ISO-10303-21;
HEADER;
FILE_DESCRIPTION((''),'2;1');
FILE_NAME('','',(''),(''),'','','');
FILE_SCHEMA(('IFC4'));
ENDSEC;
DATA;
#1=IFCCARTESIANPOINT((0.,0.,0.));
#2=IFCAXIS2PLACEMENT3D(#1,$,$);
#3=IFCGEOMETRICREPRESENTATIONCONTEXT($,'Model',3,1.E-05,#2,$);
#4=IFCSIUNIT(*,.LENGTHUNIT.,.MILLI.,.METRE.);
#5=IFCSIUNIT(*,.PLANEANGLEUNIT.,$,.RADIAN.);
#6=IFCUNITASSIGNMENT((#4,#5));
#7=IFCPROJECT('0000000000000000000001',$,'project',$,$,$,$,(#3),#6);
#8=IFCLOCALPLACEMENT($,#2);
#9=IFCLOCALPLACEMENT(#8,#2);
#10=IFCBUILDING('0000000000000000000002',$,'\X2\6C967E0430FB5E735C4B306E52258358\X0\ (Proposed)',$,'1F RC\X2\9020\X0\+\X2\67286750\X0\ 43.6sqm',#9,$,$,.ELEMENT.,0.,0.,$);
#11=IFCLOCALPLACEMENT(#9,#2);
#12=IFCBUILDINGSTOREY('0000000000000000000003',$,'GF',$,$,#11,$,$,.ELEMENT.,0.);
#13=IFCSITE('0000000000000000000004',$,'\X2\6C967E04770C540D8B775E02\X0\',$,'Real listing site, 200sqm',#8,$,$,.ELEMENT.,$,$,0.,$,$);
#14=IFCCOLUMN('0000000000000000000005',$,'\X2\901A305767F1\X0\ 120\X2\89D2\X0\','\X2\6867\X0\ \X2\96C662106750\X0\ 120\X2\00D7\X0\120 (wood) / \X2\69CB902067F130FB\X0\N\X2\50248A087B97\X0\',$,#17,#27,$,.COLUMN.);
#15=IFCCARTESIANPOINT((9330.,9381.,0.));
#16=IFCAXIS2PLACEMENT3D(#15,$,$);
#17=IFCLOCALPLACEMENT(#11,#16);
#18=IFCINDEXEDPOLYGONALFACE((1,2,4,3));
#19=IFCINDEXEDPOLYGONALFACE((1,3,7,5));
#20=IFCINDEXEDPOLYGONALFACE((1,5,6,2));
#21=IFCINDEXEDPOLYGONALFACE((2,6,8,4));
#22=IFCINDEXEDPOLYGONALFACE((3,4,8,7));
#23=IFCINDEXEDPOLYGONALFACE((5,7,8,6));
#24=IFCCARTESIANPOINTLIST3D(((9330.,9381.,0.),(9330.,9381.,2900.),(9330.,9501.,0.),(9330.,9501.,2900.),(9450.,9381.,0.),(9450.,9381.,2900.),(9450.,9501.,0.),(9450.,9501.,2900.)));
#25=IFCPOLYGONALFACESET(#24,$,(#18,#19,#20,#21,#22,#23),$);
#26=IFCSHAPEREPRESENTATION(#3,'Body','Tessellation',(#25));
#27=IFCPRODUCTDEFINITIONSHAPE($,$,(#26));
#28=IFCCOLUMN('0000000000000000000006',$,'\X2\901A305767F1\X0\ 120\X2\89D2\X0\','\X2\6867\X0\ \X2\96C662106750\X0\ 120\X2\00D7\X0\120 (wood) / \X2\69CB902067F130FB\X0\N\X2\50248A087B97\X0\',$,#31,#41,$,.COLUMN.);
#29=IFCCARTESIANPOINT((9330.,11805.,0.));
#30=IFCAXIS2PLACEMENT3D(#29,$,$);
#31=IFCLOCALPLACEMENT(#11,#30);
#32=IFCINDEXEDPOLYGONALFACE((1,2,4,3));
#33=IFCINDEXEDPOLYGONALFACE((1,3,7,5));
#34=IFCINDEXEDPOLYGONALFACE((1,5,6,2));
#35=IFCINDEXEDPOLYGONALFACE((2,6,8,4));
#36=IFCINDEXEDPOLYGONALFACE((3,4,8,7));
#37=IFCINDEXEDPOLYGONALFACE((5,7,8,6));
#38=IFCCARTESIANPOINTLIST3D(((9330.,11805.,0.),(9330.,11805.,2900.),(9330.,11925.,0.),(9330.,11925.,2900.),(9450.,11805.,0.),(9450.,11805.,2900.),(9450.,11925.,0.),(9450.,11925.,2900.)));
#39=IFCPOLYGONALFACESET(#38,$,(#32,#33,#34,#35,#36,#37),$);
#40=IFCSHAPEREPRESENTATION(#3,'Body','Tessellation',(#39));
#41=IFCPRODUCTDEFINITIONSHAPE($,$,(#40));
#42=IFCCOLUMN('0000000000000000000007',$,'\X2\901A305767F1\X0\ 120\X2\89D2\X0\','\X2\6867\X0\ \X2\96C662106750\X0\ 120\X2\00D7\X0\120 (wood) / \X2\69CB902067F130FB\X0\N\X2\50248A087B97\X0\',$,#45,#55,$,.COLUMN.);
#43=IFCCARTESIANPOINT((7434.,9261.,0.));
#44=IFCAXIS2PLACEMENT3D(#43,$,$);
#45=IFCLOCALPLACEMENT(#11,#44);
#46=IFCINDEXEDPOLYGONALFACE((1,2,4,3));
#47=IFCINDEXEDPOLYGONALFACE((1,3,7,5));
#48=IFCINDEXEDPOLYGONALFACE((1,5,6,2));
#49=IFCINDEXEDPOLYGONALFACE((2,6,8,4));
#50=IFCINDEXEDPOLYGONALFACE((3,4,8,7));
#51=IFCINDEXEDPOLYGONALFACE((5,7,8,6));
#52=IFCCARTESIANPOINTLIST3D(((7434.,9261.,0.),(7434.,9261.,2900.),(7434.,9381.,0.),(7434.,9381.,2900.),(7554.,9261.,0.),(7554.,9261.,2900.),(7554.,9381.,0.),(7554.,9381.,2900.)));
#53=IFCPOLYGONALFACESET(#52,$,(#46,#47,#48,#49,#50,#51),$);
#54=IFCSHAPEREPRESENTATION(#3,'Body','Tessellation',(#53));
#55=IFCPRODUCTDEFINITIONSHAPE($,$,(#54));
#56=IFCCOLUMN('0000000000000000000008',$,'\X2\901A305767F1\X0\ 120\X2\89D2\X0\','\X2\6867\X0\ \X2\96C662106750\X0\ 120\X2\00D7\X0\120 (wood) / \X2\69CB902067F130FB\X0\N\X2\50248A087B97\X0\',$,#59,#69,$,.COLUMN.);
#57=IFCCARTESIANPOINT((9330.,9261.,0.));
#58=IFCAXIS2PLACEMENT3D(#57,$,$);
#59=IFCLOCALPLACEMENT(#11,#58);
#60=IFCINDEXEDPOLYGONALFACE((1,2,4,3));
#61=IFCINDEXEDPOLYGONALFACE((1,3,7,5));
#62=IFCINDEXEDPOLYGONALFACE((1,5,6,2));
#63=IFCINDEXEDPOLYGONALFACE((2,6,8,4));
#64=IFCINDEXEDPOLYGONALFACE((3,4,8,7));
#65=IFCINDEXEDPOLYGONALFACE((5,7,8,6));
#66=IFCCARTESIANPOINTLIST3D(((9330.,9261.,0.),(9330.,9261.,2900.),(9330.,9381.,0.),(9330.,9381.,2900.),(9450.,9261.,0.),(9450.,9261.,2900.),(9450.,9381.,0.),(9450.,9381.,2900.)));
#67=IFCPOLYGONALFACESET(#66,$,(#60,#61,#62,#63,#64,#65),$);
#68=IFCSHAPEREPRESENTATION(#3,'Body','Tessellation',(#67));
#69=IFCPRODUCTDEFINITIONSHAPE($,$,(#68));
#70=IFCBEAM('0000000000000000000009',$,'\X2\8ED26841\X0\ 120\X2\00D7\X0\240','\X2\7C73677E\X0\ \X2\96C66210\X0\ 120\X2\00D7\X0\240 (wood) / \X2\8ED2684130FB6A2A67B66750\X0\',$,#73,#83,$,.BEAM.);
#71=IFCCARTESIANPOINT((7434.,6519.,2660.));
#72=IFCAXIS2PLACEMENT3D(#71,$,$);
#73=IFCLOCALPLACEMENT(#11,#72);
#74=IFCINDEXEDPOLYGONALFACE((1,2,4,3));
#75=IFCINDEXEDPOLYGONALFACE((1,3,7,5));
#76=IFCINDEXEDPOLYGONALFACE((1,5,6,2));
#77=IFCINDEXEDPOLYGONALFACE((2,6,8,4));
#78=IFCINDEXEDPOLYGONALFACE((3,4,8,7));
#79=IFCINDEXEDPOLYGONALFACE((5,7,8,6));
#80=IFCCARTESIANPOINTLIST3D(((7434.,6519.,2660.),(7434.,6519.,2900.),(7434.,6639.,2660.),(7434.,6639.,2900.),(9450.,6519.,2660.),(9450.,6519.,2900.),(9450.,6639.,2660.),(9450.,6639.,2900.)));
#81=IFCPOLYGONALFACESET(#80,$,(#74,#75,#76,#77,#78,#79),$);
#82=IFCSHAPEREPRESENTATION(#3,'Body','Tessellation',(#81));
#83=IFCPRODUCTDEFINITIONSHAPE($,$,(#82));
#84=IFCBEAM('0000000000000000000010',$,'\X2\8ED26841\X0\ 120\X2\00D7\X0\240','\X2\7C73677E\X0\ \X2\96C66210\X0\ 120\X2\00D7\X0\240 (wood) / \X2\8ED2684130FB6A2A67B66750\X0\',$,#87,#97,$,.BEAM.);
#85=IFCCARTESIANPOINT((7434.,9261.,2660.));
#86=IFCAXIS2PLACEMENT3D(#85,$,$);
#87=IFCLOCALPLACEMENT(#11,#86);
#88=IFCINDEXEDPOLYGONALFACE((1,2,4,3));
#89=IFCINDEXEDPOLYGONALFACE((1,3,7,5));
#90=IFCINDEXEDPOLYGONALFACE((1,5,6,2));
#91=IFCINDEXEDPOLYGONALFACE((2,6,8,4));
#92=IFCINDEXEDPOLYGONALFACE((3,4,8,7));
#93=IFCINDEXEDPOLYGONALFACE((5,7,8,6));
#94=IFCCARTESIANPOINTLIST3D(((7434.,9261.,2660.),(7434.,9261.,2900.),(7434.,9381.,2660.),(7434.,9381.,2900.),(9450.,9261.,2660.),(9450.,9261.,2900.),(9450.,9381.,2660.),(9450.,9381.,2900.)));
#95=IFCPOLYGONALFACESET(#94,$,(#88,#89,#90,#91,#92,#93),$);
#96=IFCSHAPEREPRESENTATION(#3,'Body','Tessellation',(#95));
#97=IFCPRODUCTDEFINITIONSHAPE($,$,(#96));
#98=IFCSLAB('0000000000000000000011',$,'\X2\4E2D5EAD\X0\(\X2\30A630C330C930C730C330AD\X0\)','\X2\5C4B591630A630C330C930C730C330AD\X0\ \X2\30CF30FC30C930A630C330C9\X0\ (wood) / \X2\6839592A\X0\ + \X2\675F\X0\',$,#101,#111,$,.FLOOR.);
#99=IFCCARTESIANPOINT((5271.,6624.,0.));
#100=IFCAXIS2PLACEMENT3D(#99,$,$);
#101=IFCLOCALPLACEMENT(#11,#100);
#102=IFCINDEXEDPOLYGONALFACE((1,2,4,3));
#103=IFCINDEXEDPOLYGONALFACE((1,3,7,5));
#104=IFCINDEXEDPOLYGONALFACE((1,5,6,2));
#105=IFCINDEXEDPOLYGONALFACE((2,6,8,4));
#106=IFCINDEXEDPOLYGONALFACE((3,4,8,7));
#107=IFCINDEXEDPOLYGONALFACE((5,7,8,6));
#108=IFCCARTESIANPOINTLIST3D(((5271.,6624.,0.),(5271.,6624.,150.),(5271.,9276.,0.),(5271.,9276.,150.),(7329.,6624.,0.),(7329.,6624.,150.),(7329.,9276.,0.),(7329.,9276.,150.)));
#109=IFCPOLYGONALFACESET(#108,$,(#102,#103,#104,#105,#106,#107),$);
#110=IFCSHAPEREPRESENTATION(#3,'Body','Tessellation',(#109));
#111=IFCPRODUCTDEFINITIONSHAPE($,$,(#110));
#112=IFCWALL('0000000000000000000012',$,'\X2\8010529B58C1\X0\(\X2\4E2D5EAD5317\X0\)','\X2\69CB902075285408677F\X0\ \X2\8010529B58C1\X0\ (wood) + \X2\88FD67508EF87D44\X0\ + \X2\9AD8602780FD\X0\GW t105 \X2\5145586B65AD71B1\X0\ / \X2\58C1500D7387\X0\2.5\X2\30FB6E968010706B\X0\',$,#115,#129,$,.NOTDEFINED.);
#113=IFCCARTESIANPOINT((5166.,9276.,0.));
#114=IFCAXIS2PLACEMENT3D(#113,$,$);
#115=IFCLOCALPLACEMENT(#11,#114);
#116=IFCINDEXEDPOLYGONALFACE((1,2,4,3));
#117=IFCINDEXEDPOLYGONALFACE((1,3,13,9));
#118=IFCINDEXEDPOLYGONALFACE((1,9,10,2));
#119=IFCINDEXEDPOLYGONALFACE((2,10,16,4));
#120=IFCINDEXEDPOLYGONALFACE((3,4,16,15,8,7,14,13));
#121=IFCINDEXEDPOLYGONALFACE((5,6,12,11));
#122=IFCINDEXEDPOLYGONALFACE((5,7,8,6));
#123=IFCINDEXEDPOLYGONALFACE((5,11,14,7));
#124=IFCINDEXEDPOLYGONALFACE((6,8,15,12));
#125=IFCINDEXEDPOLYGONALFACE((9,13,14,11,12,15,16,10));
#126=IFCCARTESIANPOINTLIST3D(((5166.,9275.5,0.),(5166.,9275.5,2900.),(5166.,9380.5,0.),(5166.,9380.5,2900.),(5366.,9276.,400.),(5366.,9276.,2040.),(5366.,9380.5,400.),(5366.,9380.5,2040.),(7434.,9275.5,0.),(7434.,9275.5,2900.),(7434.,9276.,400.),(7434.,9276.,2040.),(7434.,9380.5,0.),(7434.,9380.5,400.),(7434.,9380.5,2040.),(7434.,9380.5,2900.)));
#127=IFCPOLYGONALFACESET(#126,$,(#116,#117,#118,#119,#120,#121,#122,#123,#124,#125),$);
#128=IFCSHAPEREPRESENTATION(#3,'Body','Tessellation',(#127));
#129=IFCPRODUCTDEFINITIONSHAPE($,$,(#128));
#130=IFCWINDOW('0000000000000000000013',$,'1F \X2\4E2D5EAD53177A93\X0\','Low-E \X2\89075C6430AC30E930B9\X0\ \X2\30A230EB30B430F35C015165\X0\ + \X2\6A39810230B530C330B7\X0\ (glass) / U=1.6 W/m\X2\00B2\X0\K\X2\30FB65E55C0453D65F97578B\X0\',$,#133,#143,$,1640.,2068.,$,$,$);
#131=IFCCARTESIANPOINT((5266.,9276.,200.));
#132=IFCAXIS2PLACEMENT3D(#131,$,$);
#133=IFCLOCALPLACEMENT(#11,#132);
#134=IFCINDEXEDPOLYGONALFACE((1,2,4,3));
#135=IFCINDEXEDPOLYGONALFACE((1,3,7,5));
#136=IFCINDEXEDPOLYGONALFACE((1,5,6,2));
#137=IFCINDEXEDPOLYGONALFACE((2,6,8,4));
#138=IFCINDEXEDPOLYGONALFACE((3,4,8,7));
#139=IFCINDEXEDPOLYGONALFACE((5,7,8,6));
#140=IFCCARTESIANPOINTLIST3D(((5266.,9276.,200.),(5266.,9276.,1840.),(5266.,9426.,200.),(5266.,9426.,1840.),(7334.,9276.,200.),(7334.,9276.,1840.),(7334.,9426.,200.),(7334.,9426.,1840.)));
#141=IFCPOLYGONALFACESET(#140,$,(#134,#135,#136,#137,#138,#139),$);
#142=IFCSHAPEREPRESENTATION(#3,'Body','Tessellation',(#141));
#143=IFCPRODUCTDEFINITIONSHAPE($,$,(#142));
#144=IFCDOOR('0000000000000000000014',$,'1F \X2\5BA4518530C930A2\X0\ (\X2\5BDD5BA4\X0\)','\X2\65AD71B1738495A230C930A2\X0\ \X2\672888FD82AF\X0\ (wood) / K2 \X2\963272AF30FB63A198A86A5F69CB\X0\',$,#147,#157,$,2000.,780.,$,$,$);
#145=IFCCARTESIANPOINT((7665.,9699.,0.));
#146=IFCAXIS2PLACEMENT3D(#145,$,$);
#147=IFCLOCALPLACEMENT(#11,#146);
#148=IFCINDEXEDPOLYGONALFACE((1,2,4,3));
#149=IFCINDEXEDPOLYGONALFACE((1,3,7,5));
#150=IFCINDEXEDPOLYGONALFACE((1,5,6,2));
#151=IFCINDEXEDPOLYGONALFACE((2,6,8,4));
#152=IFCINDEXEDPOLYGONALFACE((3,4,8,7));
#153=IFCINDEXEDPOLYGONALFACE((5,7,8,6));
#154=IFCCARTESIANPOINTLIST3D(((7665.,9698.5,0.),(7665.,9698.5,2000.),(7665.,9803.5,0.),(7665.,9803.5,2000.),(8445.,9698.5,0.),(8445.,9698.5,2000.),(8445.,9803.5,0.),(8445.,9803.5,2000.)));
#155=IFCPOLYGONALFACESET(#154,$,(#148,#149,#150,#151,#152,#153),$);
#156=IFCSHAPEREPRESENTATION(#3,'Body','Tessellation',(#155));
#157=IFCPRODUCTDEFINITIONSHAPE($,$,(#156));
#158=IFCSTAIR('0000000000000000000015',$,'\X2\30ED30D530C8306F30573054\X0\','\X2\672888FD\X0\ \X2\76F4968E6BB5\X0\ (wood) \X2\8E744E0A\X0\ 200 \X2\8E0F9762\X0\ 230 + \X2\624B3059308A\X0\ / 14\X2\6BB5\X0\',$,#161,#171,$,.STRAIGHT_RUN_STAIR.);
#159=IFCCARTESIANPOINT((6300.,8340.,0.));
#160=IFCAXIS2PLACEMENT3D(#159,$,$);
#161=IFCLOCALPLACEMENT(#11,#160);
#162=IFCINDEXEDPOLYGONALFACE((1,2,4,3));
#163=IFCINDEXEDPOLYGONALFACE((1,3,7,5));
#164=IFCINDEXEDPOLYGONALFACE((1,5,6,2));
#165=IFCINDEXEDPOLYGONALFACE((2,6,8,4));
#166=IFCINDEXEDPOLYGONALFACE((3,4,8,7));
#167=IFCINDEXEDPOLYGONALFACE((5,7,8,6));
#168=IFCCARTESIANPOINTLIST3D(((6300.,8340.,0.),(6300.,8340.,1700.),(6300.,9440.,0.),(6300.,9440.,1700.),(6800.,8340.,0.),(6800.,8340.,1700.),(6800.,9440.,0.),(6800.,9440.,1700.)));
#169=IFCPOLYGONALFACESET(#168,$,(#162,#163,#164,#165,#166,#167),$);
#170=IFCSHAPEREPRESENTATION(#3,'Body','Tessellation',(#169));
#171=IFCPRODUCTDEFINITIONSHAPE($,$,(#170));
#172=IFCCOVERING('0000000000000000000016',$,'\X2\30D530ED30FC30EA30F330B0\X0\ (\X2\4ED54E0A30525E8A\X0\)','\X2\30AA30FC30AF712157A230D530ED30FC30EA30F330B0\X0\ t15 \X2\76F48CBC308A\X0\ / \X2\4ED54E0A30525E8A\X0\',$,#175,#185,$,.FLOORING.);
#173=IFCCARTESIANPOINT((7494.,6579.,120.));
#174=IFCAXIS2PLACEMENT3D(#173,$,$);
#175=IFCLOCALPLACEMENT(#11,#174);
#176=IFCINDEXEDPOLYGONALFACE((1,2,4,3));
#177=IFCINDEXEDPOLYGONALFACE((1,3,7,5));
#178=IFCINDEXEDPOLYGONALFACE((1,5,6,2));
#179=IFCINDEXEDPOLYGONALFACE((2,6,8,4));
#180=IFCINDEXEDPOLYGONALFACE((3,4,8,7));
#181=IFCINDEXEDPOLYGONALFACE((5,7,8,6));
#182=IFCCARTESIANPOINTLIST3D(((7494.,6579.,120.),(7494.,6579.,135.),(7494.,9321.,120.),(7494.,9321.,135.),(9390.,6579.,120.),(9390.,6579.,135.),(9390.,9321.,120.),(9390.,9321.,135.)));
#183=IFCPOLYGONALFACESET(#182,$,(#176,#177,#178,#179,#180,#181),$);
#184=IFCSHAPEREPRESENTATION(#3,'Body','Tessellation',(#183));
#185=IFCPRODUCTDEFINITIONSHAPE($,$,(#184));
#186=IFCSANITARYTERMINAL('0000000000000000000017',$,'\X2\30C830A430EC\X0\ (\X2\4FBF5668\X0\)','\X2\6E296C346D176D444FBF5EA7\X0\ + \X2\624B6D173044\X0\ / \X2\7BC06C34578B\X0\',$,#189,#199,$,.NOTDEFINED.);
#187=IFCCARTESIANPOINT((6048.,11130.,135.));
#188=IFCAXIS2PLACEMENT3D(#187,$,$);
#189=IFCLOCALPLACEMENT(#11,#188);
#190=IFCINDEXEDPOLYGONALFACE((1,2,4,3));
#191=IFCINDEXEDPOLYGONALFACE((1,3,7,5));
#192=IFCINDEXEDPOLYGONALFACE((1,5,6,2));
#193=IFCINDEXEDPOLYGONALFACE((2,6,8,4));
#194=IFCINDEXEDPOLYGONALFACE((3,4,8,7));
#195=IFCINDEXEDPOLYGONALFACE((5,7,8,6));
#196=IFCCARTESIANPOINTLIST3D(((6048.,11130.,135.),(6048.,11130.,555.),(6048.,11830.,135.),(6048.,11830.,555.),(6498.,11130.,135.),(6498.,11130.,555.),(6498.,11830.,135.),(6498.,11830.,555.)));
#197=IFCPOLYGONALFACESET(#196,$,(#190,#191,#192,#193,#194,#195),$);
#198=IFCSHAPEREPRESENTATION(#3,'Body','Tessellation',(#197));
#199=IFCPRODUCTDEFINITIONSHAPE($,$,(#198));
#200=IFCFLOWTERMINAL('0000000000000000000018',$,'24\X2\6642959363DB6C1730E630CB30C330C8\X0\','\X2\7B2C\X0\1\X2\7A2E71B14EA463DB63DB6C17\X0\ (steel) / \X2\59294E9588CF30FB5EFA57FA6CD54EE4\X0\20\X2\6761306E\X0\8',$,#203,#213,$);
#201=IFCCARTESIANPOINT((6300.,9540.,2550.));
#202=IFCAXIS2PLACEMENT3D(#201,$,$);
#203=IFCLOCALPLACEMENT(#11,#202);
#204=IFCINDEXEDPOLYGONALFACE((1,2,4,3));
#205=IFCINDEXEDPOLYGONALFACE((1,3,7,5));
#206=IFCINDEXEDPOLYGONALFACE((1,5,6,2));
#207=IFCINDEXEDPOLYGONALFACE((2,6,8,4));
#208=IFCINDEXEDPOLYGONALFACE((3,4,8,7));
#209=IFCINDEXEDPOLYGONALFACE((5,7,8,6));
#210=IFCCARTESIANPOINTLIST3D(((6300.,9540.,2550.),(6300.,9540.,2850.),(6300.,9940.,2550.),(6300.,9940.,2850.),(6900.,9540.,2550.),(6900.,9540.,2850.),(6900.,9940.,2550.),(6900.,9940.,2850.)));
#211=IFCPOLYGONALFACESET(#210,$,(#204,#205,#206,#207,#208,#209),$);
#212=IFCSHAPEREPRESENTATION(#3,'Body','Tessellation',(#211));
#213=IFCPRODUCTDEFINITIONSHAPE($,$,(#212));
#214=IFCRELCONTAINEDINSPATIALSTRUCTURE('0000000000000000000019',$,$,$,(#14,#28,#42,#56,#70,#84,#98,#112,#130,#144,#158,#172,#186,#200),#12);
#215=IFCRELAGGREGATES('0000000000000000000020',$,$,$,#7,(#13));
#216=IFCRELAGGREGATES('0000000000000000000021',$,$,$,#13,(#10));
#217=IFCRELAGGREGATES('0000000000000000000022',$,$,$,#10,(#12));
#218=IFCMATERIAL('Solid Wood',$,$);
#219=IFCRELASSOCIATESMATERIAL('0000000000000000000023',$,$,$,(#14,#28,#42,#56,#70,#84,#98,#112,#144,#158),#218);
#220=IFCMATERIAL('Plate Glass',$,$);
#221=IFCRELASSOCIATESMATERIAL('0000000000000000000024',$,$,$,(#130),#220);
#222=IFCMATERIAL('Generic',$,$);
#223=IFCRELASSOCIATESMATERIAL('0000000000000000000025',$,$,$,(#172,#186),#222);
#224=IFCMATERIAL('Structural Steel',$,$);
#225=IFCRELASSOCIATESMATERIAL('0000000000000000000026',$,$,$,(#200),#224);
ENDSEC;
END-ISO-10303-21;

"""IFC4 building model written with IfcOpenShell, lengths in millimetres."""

from ifc_helpers import new_model, si_unit, frame, frame_2d, origin, place, context, project, spatial, rectangle, extrude, material, element, fill, save


model = new_model("IFC4")

# Units and contexts
model_context = context("Model", 3, precision=1e-05, world=origin())
ifc_project = project(units=[si_unit("LENGTHUNIT", "METRE", prefix="MILLI"), si_unit("PLANEANGLEUNIT", "RADIAN")], contexts=[model_context])

# Site, building, storey
site_placement = place(None, origin())
site = spatial("IfcSite", under=ifc_project, at=site_placement, Name="沖縄県名護市", ObjectType="Real listing site, 200sqm", CompositionType="ELEMENT", RefElevation=0.0)
building_placement = place(site_placement, origin())
building = spatial("IfcBuilding", under=site, at=building_placement, Name="沖縄・平屋の別荘 (Proposed)", ObjectType="1F RC造+木材 43.6sqm", CompositionType="ELEMENT", ElevationOfRefHeight=0.0, ElevationOfTerrain=0.0)
storey_placement = place(building_placement, origin())
storey = spatial("IfcBuildingStorey", under=building, at=storey_placement, Name="GF", CompositionType="ELEMENT", Elevation=0.0)

# Columns
ifc_material_1 = material(Name="Solid Wood")
column_1_placement = place(storey_placement, frame((9330.0, 9381.0, 0.0)))
element("IfcColumn", 1, at=column_1_placement, inside=storey, material=ifc_material_1, Name="通し柱 120角", Description="桧 集成材 120×120 (wood) / 構造柱・N値計算", PredefinedType="COLUMN", context=model_context, shape_type="SweptSolid", body=[
    extrude(rectangle(XDim=120.0, YDim=120.0, at=frame_2d((60.0, 60.0))), frame((9330.0, 9381.0, 0.0)), (0.0, 0.0, 1.0), 2900.0),
])
column_2_placement = place(storey_placement, frame((9330.0, 11805.0, 0.0)))
element("IfcColumn", 2, at=column_2_placement, inside=storey, material=ifc_material_1, Name="通し柱 120角", Description="桧 集成材 120×120 (wood) / 構造柱・N値計算", PredefinedType="COLUMN", context=model_context, shape_type="SweptSolid", body=[
    extrude(rectangle(XDim=120.0, YDim=120.0, at=frame_2d((60.0, 60.0))), frame((9330.0, 11805.0, 0.0)), (0.0, 0.0, 1.0), 2900.0),
])
column_3_placement = place(storey_placement, frame((7434.0, 9261.0, 0.0)))
element("IfcColumn", 3, at=column_3_placement, inside=storey, material=ifc_material_1, Name="通し柱 120角", Description="桧 集成材 120×120 (wood) / 構造柱・N値計算", PredefinedType="COLUMN", context=model_context, shape_type="SweptSolid", body=[
    extrude(rectangle(XDim=120.0, YDim=120.0, at=frame_2d((60.0, 60.0))), frame((7434.0, 9261.0, 0.0)), (0.0, 0.0, 1.0), 2900.0),
])
column_4_placement = place(storey_placement, frame((9330.0, 9261.0, 0.0)))
element("IfcColumn", 4, at=column_4_placement, inside=storey, material=ifc_material_1, Name="通し柱 120角", Description="桧 集成材 120×120 (wood) / 構造柱・N値計算", PredefinedType="COLUMN", context=model_context, shape_type="SweptSolid", body=[
    extrude(rectangle(XDim=120.0, YDim=120.0, at=frame_2d((60.0, 60.0))), frame((9330.0, 9261.0, 0.0)), (0.0, 0.0, 1.0), 2900.0),
])

# Beams
beam_1_placement = place(storey_placement, frame((7434.0, 6519.0, 2660.0)))
element("IfcBeam", 5, at=beam_1_placement, inside=storey, material=ifc_material_1, Name="軒桁 120×240", Description="米松 集成 120×240 (wood) / 軒桁・横架材", PredefinedType="BEAM", context=model_context, shape_type="SweptSolid", body=[
    extrude(rectangle(XDim=2016.0, YDim=120.0, at=frame_2d((1008.0, 60.0))), frame((7434.0, 6519.0, 2660.0)), (0.0, 0.0, 1.0), 240.0),
])
beam_2_placement = place(storey_placement, frame((7434.0, 9261.0, 2660.0)))
element("IfcBeam", 6, at=beam_2_placement, inside=storey, material=ifc_material_1, Name="軒桁 120×240", Description="米松 集成 120×240 (wood) / 軒桁・横架材", PredefinedType="BEAM", context=model_context, shape_type="SweptSolid", body=[
    extrude(rectangle(XDim=2016.0, YDim=120.0, at=frame_2d((1008.0, 60.0))), frame((7434.0, 9261.0, 2660.0)), (0.0, 0.0, 1.0), 240.0),
])

# Slab
slab_placement = place(storey_placement, frame((5271.0, 6624.0, 0.0)))
element("IfcSlab", 7, at=slab_placement, inside=storey, material=ifc_material_1, Name="中庭(ウッドデッキ)", Description="屋外ウッドデッキ ハードウッド (wood) / 根太 + 束", PredefinedType="FLOOR", context=model_context, shape_type="SweptSolid", body=[
    extrude(rectangle(XDim=2058.0, YDim=2652.0, at=frame_2d((1029.0, 1326.0))), frame((5271.0, 6624.0, 0.0)), (0.0, 0.0, 1.0), 150.0),
])

# Wall, opening, window
wall_1_placement = place(storey_placement, frame((5166.0, 9276.0, 0.0)))
wall_1 = element("IfcWall", 8, at=wall_1_placement, inside=storey, material=ifc_material_1, Name="耐力壁(中庭北)", Description="構造用合板 耐力壁 (wood) + 製材軸組 + 高性能GW t105 充填断熱 / 壁倍率2.5・準耐火", PredefinedType="NOTDEFINED", context=model_context, shape_type="SweptSolid", body=[
    extrude(rectangle(XDim=2268.0, YDim=105.0, at=frame_2d((1134.0, 52.0))), frame((5166.0, 9276.0, 0.0)), (0.0, 0.0, 1.0), 2900.0),
])
opening_placement = place(storey_placement, frame((5266.0, 9276.0, 200.0)))
opening = element("IfcOpeningElement", 9, at=opening_placement, cuts=wall_1, PredefinedType="NOTDEFINED", context=model_context, shape_type="SweptSolid", body=[
    extrude(rectangle(XDim=2068.0, YDim=150.0, at=frame_2d((1034.0, 75.0))), frame((5266.0, 9276.0, 200.0)), (0.0, 0.0, 1.0), 1640.0),
])
ifc_material_2 = material(Name="Plate Glass")
window_placement = place(storey_placement, frame((5266.0, 9276.0, 200.0)))
window = element("IfcWindow", 10, at=window_placement, inside=storey, material=ifc_material_2, Name="1F 中庭北窓", Description="Low-E 複層ガラス アルゴン封入 + 樹脂サッシ (glass) / U=1.6 W/m²K・日射取得型", OverallHeight=1640.0, OverallWidth=2068.0, context=model_context, shape_type="SweptSolid", body=[
    extrude(rectangle(XDim=2068.0, YDim=150.0, at=frame_2d((1034.0, 75.0))), frame((5266.0, 9276.0, 200.0)), (0.0, 0.0, 1.0), 1640.0),
])
fill(opening, window)

# Door
door_placement = place(storey_placement, frame((7665.0, 9699.0, 0.0)))
element("IfcDoor", 11, at=door_placement, inside=storey, material=ifc_material_1, Name="1F 室内ドア (寝室)", Description="断熱玄関ドア 木製芯 (wood) / K2 防犯・採風機構", OverallHeight=2000.0, OverallWidth=780.0, context=model_context, shape_type="SweptSolid", body=[
    extrude(rectangle(XDim=780.0, YDim=105.0, at=frame_2d((390.0, 52.0))), frame((7665.0, 9699.0, 0.0)), (0.0, 0.0, 1.0), 2000.0),
])

# Stair
stair_placement = place(storey_placement, frame((6300.0, 8340.0, 0.0)))
element("IfcStair", 12, at=stair_placement, inside=storey, material=ifc_material_1, Name="ロフトはしご", Description="木製 直階段 (wood) 蹴上 200 踏面 230 + 手すり / 14段", PredefinedType="STRAIGHT_RUN_STAIR", context=model_context, shape_type="SweptSolid", body=[
    extrude(rectangle(XDim=500.0, YDim=1100.0, at=frame_2d((250.0, 550.0))), frame((6300.0, 8340.0, 0.0)), (0.0, 0.0, 1.0), 1700.0),
])

# Covering
ifc_material_3 = material(Name="Generic")
covering_placement = place(storey_placement, frame((7494.0, 6579.0, 120.0)))
element("IfcCovering", 13, at=covering_placement, inside=storey, material=ifc_material_3, Name="フローリング (仕上げ床)", Description="オーク無垢フローリング t15 直貼り / 仕上げ床", PredefinedType="FLOORING", context=model_context, shape_type="SweptSolid", body=[
    extrude(rectangle(XDim=1896.0, YDim=2742.0, at=frame_2d((948.0, 1371.0))), frame((7494.0, 6579.0, 120.0)), (0.0, 0.0, 1.0), 15.0),
])

# Sanitary terminal
sanitary_terminal_placement = place(storey_placement, frame((6048.0, 11130.0, 135.0)))
element("IfcSanitaryTerminal", 14, at=sanitary_terminal_placement, inside=storey, material=ifc_material_3, Name="トイレ (便器)", Description="温水洗浄便座 + 手洗い / 節水型", PredefinedType="NOTDEFINED", context=model_context, shape_type="SweptSolid", body=[
    extrude(rectangle(XDim=450.0, YDim=700.0, at=frame_2d((225.0, 350.0))), frame((6048.0, 11130.0, 135.0)), (0.0, 0.0, 1.0), 420.0),
])

# Flow terminal
ifc_material_4 = material(Name="Structural Steel")
flow_terminal_placement = place(storey_placement, frame((6300.0, 9540.0, 2550.0)))
element("IfcFlowTerminal", 15, at=flow_terminal_placement, inside=storey, material=ifc_material_4, Name="24時間換気ユニット", Description="第1種熱交換換気 (steel) / 天井裏・建基法令20条の8", context=model_context, shape_type="SweptSolid", body=[
    extrude(rectangle(XDim=600.0, YDim=400.0, at=frame_2d((300.0, 200.0))), frame((6300.0, 9540.0, 2550.0)), (0.0, 0.0, 1.0), 300.0),
])

save(model, "model.ifc")
